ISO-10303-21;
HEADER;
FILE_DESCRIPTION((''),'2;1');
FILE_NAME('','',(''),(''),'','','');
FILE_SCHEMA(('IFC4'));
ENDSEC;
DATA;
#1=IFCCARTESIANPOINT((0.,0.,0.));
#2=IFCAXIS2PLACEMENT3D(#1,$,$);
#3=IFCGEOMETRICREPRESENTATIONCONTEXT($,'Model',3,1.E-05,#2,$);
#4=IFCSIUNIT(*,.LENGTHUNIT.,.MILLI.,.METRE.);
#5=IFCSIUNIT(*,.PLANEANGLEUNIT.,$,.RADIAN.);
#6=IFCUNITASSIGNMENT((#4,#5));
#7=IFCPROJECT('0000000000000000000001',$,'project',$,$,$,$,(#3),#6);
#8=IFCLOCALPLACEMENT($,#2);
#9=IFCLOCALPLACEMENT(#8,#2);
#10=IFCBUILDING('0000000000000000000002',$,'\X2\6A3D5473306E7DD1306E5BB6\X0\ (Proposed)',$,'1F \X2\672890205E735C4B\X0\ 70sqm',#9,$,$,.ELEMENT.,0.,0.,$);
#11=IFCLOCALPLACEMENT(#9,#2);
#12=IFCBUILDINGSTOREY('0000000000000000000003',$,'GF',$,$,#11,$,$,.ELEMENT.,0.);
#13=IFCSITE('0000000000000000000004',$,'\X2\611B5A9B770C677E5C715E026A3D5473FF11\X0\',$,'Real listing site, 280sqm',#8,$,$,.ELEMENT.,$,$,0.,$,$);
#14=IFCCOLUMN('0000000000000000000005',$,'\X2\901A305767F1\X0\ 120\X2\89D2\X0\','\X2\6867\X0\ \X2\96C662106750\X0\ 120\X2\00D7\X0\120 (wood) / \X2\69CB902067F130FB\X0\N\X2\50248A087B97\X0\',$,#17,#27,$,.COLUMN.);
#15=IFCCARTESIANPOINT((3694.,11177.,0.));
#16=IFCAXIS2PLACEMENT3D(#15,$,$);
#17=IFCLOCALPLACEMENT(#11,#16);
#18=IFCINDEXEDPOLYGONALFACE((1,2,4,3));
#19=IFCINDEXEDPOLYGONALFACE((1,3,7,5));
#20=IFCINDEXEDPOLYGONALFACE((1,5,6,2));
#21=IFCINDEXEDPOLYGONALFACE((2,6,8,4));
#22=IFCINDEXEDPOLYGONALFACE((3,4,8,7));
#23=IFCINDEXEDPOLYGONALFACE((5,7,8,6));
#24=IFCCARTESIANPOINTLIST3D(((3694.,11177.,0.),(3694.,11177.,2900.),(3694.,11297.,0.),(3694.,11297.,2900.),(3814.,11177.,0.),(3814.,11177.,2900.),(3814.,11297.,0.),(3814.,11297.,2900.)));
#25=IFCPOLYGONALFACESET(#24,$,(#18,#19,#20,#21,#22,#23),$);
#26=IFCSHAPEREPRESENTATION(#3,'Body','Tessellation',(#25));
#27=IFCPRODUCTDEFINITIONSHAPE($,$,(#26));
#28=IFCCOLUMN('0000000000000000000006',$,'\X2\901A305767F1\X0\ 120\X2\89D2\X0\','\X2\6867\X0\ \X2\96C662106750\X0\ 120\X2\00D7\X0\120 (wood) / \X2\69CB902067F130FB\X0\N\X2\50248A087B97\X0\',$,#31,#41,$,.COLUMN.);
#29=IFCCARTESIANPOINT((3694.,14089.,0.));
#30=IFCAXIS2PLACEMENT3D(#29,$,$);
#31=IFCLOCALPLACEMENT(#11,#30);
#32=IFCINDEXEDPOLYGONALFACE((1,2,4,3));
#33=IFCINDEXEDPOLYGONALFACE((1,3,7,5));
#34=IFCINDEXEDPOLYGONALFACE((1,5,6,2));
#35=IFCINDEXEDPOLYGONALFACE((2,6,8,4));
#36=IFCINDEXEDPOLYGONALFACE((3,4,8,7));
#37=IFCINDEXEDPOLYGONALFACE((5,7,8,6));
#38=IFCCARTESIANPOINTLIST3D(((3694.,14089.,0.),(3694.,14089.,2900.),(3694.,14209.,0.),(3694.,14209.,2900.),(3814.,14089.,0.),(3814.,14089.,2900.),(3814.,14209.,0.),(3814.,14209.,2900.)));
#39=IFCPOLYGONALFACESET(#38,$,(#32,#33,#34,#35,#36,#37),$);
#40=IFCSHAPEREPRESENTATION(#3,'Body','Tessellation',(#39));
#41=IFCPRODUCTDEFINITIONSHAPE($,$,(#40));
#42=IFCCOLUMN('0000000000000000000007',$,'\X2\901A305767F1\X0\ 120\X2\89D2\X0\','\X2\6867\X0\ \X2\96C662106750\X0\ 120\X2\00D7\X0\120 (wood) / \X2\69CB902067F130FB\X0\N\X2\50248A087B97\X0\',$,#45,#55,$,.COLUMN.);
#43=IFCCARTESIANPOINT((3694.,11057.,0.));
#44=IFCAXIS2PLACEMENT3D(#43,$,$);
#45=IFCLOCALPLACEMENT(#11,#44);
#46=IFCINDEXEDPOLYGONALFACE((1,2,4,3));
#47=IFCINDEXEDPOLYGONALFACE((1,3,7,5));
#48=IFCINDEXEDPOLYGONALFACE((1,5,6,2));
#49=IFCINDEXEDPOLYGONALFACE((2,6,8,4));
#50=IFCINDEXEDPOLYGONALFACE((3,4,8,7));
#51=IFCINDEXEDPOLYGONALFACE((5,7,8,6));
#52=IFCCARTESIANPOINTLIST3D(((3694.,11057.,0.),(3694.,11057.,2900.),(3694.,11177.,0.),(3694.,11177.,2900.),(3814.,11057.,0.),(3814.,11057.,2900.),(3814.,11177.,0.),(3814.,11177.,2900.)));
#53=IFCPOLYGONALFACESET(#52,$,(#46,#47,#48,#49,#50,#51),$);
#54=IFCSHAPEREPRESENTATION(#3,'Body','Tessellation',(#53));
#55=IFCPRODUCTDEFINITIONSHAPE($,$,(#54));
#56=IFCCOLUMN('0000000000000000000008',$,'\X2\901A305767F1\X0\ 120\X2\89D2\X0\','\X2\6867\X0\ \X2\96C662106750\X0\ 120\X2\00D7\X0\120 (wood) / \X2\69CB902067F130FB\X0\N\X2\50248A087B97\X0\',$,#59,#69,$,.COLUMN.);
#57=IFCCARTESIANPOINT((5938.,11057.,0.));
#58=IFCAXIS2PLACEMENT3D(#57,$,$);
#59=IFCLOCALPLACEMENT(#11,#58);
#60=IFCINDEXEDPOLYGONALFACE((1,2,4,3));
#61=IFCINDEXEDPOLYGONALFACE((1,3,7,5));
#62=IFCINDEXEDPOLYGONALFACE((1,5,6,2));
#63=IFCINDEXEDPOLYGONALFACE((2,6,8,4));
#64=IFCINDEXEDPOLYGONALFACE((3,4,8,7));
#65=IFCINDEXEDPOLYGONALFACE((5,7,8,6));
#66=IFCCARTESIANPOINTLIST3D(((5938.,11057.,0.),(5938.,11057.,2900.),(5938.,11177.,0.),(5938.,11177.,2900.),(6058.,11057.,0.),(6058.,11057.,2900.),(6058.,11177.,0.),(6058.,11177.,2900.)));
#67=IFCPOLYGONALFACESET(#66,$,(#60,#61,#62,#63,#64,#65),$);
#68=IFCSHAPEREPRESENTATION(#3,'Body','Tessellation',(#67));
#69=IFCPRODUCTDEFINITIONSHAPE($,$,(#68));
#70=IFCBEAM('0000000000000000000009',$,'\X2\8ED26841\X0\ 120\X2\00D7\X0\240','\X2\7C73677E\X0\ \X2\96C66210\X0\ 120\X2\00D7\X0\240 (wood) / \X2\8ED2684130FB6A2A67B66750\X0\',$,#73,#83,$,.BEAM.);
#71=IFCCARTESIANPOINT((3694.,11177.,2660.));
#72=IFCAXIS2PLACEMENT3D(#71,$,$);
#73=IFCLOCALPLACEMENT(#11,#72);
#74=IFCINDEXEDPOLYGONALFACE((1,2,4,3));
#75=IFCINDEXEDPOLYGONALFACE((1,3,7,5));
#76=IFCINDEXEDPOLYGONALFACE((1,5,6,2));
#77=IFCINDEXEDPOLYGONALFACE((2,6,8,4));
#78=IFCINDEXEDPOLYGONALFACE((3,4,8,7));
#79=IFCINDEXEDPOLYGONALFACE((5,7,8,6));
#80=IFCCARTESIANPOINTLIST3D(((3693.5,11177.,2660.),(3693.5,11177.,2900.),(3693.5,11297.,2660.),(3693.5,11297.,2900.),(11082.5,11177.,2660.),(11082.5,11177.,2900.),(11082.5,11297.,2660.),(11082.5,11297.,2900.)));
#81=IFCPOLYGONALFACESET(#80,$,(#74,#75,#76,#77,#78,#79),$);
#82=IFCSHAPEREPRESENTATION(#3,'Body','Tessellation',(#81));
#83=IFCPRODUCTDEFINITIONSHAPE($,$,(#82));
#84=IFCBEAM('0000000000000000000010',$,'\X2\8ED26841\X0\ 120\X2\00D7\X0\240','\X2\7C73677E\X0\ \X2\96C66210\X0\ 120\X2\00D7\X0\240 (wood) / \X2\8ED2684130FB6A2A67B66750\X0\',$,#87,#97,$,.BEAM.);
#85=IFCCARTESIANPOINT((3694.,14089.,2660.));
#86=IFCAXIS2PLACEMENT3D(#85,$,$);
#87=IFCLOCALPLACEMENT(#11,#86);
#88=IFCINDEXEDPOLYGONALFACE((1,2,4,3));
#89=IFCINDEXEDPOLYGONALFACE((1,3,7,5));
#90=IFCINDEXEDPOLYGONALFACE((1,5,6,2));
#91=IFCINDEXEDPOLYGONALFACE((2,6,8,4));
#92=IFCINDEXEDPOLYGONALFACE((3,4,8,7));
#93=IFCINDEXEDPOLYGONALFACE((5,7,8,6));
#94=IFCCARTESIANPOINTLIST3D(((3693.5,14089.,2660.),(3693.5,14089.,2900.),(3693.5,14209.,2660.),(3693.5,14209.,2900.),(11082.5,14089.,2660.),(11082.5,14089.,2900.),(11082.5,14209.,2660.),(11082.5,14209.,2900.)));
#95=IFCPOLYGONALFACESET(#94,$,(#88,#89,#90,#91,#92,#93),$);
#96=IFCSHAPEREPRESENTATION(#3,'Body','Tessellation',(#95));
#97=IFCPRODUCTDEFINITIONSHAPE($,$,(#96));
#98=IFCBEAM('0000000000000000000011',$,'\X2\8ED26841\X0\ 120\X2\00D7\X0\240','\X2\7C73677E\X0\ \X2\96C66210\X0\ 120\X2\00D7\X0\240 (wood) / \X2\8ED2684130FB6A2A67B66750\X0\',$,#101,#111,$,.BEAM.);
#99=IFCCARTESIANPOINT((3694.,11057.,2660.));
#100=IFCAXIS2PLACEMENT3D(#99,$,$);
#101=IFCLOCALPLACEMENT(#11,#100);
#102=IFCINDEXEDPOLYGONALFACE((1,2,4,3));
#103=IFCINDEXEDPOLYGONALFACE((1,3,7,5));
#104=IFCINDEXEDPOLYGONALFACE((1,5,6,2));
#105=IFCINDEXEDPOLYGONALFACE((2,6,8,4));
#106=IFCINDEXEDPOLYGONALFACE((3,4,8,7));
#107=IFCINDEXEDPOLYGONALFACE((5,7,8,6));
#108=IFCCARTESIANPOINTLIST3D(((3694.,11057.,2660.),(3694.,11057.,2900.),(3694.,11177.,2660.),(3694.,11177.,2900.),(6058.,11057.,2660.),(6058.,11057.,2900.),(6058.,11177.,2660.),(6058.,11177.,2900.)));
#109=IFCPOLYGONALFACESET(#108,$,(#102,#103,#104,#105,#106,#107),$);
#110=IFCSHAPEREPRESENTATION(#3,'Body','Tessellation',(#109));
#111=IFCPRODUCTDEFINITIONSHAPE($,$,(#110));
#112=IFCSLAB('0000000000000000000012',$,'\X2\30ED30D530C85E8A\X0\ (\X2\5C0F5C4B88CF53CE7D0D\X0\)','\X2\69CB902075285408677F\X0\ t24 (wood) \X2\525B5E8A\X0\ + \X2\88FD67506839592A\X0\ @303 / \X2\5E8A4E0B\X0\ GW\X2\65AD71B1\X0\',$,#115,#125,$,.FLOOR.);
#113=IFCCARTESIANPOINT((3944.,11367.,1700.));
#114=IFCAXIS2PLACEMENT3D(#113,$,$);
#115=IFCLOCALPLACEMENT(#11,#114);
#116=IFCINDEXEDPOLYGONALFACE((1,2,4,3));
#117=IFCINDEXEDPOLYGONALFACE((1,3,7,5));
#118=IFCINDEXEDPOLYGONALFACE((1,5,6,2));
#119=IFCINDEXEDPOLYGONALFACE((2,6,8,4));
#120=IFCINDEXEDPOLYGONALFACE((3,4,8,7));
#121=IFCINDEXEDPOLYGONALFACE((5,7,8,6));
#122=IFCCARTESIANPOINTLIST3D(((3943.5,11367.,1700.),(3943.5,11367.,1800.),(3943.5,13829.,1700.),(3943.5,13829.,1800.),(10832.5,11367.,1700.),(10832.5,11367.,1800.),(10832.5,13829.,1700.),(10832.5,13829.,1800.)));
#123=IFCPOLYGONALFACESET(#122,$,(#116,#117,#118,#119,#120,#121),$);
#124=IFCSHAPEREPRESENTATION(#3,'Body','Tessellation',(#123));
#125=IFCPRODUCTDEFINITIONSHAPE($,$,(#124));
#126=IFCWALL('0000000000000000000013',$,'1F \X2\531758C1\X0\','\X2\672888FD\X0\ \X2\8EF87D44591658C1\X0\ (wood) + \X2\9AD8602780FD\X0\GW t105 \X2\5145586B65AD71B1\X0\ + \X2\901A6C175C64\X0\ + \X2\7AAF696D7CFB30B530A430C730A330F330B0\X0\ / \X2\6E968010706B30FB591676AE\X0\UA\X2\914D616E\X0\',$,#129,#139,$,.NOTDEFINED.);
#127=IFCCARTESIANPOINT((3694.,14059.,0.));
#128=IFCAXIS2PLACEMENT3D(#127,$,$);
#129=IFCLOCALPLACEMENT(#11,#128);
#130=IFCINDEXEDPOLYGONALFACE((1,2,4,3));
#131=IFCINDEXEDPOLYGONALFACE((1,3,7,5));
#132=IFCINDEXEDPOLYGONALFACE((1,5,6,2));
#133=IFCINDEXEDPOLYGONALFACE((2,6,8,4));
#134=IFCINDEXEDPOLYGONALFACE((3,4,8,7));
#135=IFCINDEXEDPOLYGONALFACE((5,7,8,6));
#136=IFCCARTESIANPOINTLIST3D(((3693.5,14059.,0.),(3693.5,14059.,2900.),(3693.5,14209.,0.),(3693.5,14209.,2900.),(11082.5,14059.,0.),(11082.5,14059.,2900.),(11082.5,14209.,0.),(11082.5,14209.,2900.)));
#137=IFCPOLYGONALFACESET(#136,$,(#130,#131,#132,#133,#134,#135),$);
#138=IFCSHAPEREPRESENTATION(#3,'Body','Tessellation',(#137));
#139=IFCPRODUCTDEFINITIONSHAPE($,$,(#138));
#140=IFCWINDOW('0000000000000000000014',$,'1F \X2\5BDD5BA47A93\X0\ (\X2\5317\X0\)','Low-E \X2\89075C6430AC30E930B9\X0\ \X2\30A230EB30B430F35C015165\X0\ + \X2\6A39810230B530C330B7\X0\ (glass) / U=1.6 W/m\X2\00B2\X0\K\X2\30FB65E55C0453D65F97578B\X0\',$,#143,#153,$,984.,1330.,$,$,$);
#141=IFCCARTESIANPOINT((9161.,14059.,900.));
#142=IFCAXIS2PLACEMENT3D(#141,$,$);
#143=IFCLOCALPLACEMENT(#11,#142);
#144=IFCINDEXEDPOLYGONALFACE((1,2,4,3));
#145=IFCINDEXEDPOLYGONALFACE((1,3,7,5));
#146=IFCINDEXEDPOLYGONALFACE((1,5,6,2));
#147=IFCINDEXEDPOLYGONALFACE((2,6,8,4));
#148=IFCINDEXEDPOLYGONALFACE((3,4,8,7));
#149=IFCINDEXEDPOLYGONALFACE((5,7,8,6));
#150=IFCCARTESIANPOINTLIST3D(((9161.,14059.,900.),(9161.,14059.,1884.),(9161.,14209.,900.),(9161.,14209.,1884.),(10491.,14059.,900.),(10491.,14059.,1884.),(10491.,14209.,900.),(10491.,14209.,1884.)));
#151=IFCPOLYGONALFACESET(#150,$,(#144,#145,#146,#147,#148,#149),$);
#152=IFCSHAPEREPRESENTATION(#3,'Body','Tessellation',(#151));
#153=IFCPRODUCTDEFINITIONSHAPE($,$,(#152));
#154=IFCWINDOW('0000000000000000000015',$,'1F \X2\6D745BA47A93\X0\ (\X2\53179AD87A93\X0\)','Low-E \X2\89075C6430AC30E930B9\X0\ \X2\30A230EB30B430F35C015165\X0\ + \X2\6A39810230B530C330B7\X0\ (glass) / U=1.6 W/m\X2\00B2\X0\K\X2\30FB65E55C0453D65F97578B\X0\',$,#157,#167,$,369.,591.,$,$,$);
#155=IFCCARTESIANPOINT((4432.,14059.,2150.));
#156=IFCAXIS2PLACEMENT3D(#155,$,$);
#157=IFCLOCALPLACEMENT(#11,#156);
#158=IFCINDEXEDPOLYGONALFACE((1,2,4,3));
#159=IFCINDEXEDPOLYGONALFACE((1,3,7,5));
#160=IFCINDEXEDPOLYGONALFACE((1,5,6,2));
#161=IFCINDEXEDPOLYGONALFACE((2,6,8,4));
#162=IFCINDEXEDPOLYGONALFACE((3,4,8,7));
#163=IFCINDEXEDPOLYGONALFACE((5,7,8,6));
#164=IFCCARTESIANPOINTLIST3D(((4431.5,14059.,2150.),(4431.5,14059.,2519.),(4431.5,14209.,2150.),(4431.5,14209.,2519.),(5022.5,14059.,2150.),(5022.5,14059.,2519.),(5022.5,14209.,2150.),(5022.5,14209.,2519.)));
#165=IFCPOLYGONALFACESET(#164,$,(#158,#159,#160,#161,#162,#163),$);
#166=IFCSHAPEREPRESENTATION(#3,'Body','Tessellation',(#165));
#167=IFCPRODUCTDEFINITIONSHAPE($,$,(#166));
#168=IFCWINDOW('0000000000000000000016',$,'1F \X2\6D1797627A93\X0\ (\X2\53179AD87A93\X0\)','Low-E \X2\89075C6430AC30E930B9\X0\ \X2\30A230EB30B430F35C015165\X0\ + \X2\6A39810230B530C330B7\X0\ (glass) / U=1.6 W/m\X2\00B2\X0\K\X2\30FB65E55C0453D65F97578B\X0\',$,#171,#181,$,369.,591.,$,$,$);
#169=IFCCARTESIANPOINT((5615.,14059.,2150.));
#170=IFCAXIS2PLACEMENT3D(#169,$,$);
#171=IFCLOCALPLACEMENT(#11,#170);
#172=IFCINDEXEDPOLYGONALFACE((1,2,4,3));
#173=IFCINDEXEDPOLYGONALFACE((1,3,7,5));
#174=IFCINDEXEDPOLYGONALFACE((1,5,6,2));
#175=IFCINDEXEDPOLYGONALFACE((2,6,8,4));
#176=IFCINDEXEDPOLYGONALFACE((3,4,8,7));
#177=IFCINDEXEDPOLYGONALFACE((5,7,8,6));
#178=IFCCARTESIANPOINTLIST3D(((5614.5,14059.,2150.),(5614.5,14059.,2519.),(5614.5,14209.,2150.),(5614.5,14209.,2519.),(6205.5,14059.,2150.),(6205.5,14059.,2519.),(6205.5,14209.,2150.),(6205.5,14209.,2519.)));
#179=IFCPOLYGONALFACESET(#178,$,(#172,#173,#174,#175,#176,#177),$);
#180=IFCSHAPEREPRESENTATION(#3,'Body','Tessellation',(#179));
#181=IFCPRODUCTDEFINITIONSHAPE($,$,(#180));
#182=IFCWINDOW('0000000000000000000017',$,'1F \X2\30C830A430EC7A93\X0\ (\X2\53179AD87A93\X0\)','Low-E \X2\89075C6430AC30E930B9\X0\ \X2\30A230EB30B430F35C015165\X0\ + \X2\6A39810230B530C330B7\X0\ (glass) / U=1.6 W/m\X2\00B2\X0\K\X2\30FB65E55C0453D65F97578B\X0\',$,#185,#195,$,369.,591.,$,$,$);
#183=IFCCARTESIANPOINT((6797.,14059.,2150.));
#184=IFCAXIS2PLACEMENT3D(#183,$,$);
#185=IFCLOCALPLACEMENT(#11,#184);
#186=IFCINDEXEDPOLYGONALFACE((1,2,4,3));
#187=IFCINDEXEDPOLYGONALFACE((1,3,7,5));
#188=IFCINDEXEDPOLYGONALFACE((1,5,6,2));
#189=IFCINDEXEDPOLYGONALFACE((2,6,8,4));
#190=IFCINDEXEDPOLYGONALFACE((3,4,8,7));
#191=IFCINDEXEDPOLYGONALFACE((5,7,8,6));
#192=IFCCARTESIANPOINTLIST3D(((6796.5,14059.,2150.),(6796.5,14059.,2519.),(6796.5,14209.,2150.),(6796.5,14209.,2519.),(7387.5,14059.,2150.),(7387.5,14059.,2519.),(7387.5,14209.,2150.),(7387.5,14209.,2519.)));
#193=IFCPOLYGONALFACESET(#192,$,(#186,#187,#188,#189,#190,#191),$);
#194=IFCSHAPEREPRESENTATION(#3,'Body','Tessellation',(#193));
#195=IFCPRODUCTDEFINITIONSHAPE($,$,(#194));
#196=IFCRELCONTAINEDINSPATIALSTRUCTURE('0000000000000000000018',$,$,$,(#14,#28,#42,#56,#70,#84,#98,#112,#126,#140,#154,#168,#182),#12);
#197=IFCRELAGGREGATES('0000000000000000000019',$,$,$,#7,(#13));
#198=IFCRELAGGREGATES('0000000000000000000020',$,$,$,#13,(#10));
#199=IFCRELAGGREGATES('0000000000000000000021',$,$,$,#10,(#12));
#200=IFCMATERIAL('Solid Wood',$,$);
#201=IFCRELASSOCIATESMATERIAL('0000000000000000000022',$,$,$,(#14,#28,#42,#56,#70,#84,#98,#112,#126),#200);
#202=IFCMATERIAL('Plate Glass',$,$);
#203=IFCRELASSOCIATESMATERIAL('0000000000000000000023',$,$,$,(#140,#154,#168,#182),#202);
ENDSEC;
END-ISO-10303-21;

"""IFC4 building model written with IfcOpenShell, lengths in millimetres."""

from ifc_helpers import new_model, si_unit, frame, frame_2d, origin, place, context, project, spatial, rectangle, extrude, material, element, fill, save


model = new_model("IFC4")

# Units and contexts
model_context = context("Model", 3, precision=1e-05, world=origin())
ifc_project = project(units=[si_unit("LENGTHUNIT", "METRE", prefix="MILLI"), si_unit("PLANEANGLEUNIT", "RADIAN")], contexts=[model_context])

# Site, building, storey
site_placement = place(None, origin())
site = spatial("IfcSite", under=ifc_project, at=site_placement, Name="愛媛県松山市樽味１", ObjectType="Real listing site, 280sqm", CompositionType="ELEMENT", RefElevation=0.0)
building_placement = place(site_placement, origin())
building = spatial("IfcBuilding", under=site, at=building_placement, Name="樽味の緑の家 (Proposed)", ObjectType="1F 木造平屋 70sqm", CompositionType="ELEMENT", ElevationOfRefHeight=0.0, ElevationOfTerrain=0.0)
storey_placement = place(building_placement, origin())
storey = spatial("IfcBuildingStorey", under=building, at=storey_placement, Name="GF", CompositionType="ELEMENT", Elevation=0.0)

# Columns
ifc_material_1 = material(Name="Solid Wood")
column_1_placement = place(storey_placement, frame((3694.0, 11177.0, 0.0)))
element("IfcColumn", 1, at=column_1_placement, inside=storey, material=ifc_material_1, Name="通し柱 120角", Description="桧 集成材 120×120 (wood) / 構造柱・N値計算", PredefinedType="COLUMN", context=model_context, shape_type="SweptSolid", body=[
    extrude(rectangle(XDim=120.0, YDim=120.0, at=frame_2d((60.0, 60.0))), frame((3694.0, 11177.0, 0.0)), (0.0, 0.0, 1.0), 2900.0),
])
column_2_placement = place(storey_placement, frame((3694.0, 14089.0, 0.0)))
element("IfcColumn", 2, at=column_2_placement, inside=storey, material=ifc_material_1, Name="通し柱 120角", Description="桧 集成材 120×120 (wood) / 構造柱・N値計算", PredefinedType="COLUMN", context=model_context, shape_type="SweptSolid", body=[
    extrude(rectangle(XDim=120.0, YDim=120.0, at=frame_2d((60.0, 60.0))), frame((3694.0, 14089.0, 0.0)), (0.0, 0.0, 1.0), 2900.0),
])
column_3_placement = place(storey_placement, frame((3694.0, 11057.0, 0.0)))
element("IfcColumn", 3, at=column_3_placement, inside=storey, material=ifc_material_1, Name="通し柱 120角", Description="桧 集成材 120×120 (wood) / 構造柱・N値計算", PredefinedType="COLUMN", context=model_context, shape_type="SweptSolid", body=[
    extrude(rectangle(XDim=120.0, YDim=120.0, at=frame_2d((60.0, 60.0))), frame((3694.0, 11057.0, 0.0)), (0.0, 0.0, 1.0), 2900.0),
])
column_4_placement = place(storey_placement, frame((5938.0, 11057.0, 0.0)))
element("IfcColumn", 4, at=column_4_placement, inside=storey, material=ifc_material_1, Name="通し柱 120角", Description="桧 集成材 120×120 (wood) / 構造柱・N値計算", PredefinedType="COLUMN", context=model_context, shape_type="SweptSolid", body=[
    extrude(rectangle(XDim=120.0, YDim=120.0, at=frame_2d((60.0, 60.0))), frame((5938.0, 11057.0, 0.0)), (0.0, 0.0, 1.0), 2900.0),
])

# Beams
beam_1_placement = place(storey_placement, frame((3694.0, 11177.0, 2660.0)))
element("IfcBeam", 5, at=beam_1_placement, inside=storey, material=ifc_material_1, Name="軒桁 120×240", Description="米松 集成 120×240 (wood) / 軒桁・横架材", PredefinedType="BEAM", context=model_context, shape_type="SweptSolid", body=[
    extrude(rectangle(XDim=7389.0, YDim=120.0, at=frame_2d((3694.0, 60.0))), frame((3694.0, 11177.0, 2660.0)), (0.0, 0.0, 1.0), 240.0),
])
beam_2_placement = place(storey_placement, frame((3694.0, 14089.0, 2660.0)))
element("IfcBeam", 6, at=beam_2_placement, inside=storey, material=ifc_material_1, Name="軒桁 120×240", Description="米松 集成 120×240 (wood) / 軒桁・横架材", PredefinedType="BEAM", context=model_context, shape_type="SweptSolid", body=[
    extrude(rectangle(XDim=7389.0, YDim=120.0, at=frame_2d((3694.0, 60.0))), frame((3694.0, 14089.0, 2660.0)), (0.0, 0.0, 1.0), 240.0),
])
beam_3_placement = place(storey_placement, frame((3694.0, 11057.0, 2660.0)))
element("IfcBeam", 7, at=beam_3_placement, inside=storey, material=ifc_material_1, Name="軒桁 120×240", Description="米松 集成 120×240 (wood) / 軒桁・横架材", PredefinedType="BEAM", context=model_context, shape_type="SweptSolid", body=[
    extrude(rectangle(XDim=2364.0, YDim=120.0, at=frame_2d((1182.0, 60.0))), frame((3694.0, 11057.0, 2660.0)), (0.0, 0.0, 1.0), 240.0),
])

# Slab
slab_1_placement = place(storey_placement, frame((3944.0, 11367.0, 1700.0)))
element("IfcSlab", 8, at=slab_1_placement, inside=storey, material=ifc_material_1, Name="ロフト床 (小屋裏収納)", Description="構造用合板 t24 (wood) 剛床 + 製材根太 @303 / 床下 GW断熱", PredefinedType="FLOOR", context=model_context, shape_type="SweptSolid", body=[
    extrude(rectangle(XDim=6889.0, YDim=2462.0, at=frame_2d((3444.0, 1231.0))), frame((3944.0, 11367.0, 1700.0)), (0.0, 0.0, 1.0), 100.0),
])

# Wall, openings, windows
wall_1_placement = place(storey_placement, frame((3694.0, 14059.0, 0.0)))
wall_1 = element("IfcWall", 9, at=wall_1_placement, inside=storey, material=ifc_material_1, Name="1F 北壁", Description="木製 軸組外壁 (wood) + 高性能GW t105 充填断熱 + 通気層 + 窯業系サイディング / 準耐火・外皮UA配慮", PredefinedType="NOTDEFINED", context=model_context, shape_type="SweptSolid", body=[
    extrude(rectangle(XDim=7389.0, YDim=150.0, at=frame_2d((3694.0, 75.0))), frame((3694.0, 14059.0, 0.0)), (0.0, 0.0, 1.0), 2900.0),
])
opening_1_placement = place(storey_placement, frame((9161.0, 14059.0, 900.0)))
opening_1 = element("IfcOpeningElement", 10, at=opening_1_placement, cuts=wall_1, PredefinedType="NOTDEFINED", context=model_context, shape_type="SweptSolid", body=[
    extrude(rectangle(XDim=1330.0, YDim=150.0, at=frame_2d((665.0, 75.0))), frame((9161.0, 14059.0, 900.0)), (0.0, 0.0, 1.0), 984.0),
])
opening_2_placement = place(storey_placement, frame((4432.0, 14059.0, 2150.0)))
opening_2 = element("IfcOpeningElement", 11, at=opening_2_placement, cuts=wall_1, PredefinedType="NOTDEFINED", context=model_context, shape_type="SweptSolid", body=[
    extrude(rectangle(XDim=591.0, YDim=150.0, at=frame_2d((295.0, 75.0))), frame((4432.0, 14059.0, 2150.0)), (0.0, 0.0, 1.0), 369.0),
])
opening_3_placement = place(storey_placement, frame((5615.0, 14059.0, 2150.0)))
opening_3 = element("IfcOpeningElement", 12, at=opening_3_placement, cuts=wall_1, PredefinedType="NOTDEFINED", context=model_context, shape_type="SweptSolid", body=[
    extrude(rectangle(XDim=591.0, YDim=150.0, at=frame_2d((295.0, 75.0))), frame((5615.0, 14059.0, 2150.0)), (0.0, 0.0, 1.0), 369.0),
])
opening_4_placement = place(storey_placement, frame((6797.0, 14059.0, 2150.0)))
opening_4 = element("IfcOpeningElement", 13, at=opening_4_placement, cuts=wall_1, PredefinedType="NOTDEFINED", context=model_context, shape_type="SweptSolid", body=[
    extrude(rectangle(XDim=591.0, YDim=150.0, at=frame_2d((295.0, 75.0))), frame((6797.0, 14059.0, 2150.0)), (0.0, 0.0, 1.0), 369.0),
])
ifc_material_2 = material(Name="Plate Glass")
window_1_placement = place(storey_placement, frame((9161.0, 14059.0, 900.0)))
window_1 = element("IfcWindow", 14, at=window_1_placement, inside=storey, material=ifc_material_2, Name="1F 寝室窓 (北)", Description="Low-E 複層ガラス アルゴン封入 + 樹脂サッシ (glass) / U=1.6 W/m²K・日射取得型", OverallHeight=984.0, OverallWidth=1330.0, context=model_context, shape_type="SweptSolid", body=[
    extrude(rectangle(XDim=1330.0, YDim=150.0, at=frame_2d((665.0, 75.0))), frame((9161.0, 14059.0, 900.0)), (0.0, 0.0, 1.0), 984.0),
])
fill(opening_1, window_1)
window_2_placement = place(storey_placement, frame((4432.0, 14059.0, 2150.0)))
window_2 = element("IfcWindow", 15, at=window_2_placement, inside=storey, material=ifc_material_2, Name="1F 浴室窓 (北高窓)", Description="Low-E 複層ガラス アルゴン封入 + 樹脂サッシ (glass) / U=1.6 W/m²K・日射取得型", OverallHeight=369.0, OverallWidth=591.0, context=model_context, shape_type="SweptSolid", body=[
    extrude(rectangle(XDim=591.0, YDim=150.0, at=frame_2d((295.0, 75.0))), frame((4432.0, 14059.0, 2150.0)), (0.0, 0.0, 1.0), 369.0),
])
fill(opening_2, window_2)
window_3_placement = place(storey_placement, frame((5615.0, 14059.0, 2150.0)))
window_3 = element("IfcWindow", 16, at=window_3_placement, inside=storey, material=ifc_material_2, Name="1F 洗面窓 (北高窓)", Description="Low-E 複層ガラス アルゴン封入 + 樹脂サッシ (glass) / U=1.6 W/m²K・日射取得型", OverallHeight=369.0, OverallWidth=591.0, context=model_context, shape_type="SweptSolid", body=[
    extrude(rectangle(XDim=591.0, YDim=150.0, at=frame_2d((295.0, 75.0))), frame((5615.0, 14059.0, 2150.0)), (0.0, 0.0, 1.0), 369.0),
])
fill(opening_3, window_3)
window_4_placement = place(storey_placement, frame((6797.0, 14059.0, 2150.0)))
window_4 = element("IfcWindow", 17, at=window_4_placement, inside=storey, material=ifc_material_2, Name="1F トイレ窓 (北高窓)", Description="Low-E 複層ガラス アルゴン封入 + 樹脂サッシ (glass) / U=1.6 W/m²K・日射取得型", OverallHeight=369.0, OverallWidth=591.0, context=model_context, shape_type="SweptSolid", body=[
    extrude(rectangle(XDim=591.0, YDim=150.0, at=frame_2d((295.0, 75.0))), frame((6797.0, 14059.0, 2150.0)), (0.0, 0.0, 1.0), 369.0),
])
fill(opening_4, window_4)

save(model, "model.ifc")
